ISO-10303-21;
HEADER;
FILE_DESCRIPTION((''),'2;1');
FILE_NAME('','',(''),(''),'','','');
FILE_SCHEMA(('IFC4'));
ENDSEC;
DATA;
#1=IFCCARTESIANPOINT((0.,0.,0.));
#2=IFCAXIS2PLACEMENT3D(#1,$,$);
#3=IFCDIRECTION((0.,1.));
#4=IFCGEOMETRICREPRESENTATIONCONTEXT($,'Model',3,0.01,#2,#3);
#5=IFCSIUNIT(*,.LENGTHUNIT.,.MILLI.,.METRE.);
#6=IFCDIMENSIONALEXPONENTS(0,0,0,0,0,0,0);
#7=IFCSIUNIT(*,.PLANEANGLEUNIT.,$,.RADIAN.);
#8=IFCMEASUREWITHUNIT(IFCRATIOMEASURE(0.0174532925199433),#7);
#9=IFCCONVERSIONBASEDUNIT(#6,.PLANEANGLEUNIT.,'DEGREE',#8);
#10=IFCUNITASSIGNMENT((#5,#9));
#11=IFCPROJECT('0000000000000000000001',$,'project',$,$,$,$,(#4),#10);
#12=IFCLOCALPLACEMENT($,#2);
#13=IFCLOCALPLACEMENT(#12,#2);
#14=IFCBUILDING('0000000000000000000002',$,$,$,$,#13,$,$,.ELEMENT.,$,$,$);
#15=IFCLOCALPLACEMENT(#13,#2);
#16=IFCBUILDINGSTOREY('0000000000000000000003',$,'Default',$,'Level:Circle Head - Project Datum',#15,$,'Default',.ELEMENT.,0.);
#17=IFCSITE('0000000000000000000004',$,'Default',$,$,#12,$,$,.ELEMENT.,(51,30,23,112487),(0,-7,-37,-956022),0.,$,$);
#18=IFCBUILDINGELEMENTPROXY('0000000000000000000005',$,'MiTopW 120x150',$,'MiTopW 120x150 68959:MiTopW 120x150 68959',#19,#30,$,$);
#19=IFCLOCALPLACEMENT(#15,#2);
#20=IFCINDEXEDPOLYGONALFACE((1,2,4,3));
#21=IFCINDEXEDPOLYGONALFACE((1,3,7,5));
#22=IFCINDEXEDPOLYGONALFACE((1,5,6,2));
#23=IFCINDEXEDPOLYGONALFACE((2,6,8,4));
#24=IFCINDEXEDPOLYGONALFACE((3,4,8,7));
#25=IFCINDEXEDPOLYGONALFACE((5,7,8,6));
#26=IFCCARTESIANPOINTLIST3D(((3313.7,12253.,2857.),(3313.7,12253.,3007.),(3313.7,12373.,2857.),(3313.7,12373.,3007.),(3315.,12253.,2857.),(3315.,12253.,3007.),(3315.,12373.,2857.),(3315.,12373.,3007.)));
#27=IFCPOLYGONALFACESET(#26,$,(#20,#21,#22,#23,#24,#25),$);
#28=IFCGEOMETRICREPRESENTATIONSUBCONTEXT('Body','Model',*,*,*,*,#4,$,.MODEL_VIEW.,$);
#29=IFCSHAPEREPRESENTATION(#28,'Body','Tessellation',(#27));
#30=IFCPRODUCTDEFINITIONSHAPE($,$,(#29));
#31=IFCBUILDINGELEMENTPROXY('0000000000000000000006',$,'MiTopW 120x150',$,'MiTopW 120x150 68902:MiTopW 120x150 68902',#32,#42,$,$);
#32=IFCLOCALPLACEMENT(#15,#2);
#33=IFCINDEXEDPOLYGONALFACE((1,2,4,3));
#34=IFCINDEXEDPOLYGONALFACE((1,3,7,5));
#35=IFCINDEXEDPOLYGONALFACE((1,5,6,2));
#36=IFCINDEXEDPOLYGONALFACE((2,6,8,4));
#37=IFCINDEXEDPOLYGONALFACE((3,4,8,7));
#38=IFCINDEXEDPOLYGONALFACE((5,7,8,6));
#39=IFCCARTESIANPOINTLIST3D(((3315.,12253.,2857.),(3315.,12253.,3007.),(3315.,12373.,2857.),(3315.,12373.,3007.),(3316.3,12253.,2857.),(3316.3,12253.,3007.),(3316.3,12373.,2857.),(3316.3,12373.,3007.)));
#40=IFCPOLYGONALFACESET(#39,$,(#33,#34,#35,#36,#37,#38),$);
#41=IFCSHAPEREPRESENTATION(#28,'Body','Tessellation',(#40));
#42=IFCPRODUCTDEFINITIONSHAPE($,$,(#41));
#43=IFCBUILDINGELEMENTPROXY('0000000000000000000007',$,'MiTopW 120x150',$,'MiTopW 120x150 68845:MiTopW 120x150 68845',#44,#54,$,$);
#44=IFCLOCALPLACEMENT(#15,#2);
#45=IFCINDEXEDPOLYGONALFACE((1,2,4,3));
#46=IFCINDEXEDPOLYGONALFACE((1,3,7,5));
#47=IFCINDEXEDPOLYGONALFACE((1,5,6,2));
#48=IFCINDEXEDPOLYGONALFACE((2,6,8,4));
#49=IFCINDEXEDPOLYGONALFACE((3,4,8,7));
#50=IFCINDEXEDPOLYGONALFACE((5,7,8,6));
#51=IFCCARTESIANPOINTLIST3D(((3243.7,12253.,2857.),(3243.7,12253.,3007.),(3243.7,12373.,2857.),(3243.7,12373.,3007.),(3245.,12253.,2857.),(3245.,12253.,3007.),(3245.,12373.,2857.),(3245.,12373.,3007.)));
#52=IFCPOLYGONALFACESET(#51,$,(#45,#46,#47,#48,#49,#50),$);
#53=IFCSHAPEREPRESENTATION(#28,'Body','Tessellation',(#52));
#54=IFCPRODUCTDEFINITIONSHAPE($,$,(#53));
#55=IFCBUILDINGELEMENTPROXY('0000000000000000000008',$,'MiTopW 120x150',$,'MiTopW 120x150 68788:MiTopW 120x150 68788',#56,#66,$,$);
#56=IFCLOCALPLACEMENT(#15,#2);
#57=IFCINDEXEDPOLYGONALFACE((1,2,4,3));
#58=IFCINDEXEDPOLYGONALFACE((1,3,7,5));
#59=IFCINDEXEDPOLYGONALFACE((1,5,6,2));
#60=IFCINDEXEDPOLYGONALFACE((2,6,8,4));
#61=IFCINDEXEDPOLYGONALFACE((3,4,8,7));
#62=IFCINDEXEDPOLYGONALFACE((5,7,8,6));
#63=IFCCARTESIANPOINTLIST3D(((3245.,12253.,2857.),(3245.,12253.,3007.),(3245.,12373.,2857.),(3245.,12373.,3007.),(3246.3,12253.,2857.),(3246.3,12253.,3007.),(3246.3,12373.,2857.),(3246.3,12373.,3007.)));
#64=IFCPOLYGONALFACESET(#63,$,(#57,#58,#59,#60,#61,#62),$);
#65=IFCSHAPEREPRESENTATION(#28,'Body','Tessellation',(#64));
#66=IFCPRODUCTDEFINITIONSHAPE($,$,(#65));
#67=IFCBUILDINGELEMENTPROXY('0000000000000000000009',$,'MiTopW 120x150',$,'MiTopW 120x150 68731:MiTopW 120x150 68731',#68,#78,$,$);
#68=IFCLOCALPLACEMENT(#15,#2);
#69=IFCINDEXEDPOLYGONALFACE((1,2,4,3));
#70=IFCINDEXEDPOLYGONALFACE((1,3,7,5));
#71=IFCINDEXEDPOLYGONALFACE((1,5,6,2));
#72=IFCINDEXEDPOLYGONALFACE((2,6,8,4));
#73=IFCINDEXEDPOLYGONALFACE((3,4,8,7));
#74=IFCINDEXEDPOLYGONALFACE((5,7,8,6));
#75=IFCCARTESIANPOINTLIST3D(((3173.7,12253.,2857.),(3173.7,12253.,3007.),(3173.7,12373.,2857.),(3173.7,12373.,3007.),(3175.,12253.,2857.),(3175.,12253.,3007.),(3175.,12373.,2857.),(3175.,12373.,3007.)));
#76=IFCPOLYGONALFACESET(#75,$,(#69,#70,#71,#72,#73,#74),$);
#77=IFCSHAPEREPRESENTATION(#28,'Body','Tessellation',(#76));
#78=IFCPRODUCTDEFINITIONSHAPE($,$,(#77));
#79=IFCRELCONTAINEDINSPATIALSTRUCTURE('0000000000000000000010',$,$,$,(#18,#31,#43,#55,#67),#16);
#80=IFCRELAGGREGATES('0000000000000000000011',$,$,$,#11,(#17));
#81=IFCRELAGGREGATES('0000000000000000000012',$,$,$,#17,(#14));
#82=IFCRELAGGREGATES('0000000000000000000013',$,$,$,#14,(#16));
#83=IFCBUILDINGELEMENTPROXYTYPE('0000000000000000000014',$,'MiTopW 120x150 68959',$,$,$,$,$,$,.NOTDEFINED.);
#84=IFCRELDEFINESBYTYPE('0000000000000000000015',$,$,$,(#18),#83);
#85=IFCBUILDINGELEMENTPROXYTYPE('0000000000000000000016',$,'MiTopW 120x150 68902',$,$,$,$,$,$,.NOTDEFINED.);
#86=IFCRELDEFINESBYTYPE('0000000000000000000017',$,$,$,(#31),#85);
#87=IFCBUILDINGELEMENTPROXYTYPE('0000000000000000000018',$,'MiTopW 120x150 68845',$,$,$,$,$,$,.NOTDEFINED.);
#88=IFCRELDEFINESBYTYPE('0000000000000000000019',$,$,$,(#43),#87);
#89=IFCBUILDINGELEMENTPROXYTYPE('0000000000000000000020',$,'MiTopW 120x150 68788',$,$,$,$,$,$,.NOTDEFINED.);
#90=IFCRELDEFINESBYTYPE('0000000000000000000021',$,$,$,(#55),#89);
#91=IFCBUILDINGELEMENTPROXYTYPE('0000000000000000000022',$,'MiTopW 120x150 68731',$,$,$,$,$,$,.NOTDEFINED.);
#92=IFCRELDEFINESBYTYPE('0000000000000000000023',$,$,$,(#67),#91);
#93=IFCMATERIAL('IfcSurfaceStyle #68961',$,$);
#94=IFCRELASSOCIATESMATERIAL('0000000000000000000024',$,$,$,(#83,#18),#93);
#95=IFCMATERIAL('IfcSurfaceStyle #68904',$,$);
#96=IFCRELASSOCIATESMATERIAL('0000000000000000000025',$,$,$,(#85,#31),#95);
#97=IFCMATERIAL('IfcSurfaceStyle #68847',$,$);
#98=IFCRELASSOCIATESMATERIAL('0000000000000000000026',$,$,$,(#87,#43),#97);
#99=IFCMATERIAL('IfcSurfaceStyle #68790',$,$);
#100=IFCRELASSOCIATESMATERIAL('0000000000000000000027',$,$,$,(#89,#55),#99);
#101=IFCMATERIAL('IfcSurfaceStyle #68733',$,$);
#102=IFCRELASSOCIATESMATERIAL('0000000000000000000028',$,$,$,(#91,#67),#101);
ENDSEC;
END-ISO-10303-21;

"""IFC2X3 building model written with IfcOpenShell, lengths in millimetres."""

from ifc_helpers import new_model, entity, si_unit, converted_unit, direction, frame, frame_2d, origin, place, context, subcontext, project, spatial, rectangle, extrude, source, transform, mapped, material, type_object, type_shapes, element, save


model = new_model("IFC2X3")

# Units and contexts
model_context = context("Model", 3, precision=0.01, world=origin(), true_north=direction((0.0, 1.0)))
body_context = subcontext(model_context, "Body", "Model", "MODEL_VIEW")
ifc_project = project(units=[si_unit("LENGTHUNIT", "METRE", prefix="MILLI"), converted_unit("PLANEANGLEUNIT", "DEGREE", entity("IfcRatioMeasure", 0.0174532925199433), si_unit("PLANEANGLEUNIT", "RADIAN"), dimensions=[0, 0, 0, 0, 0, 0, 0])], contexts=[model_context])

# Site, building, storey
site_placement = place(None, origin())
site = spatial("IfcSite", under=ifc_project, at=site_placement, Name="Default", CompositionType="ELEMENT", RefLatitude=(51, 30, 23, 112487), RefLongitude=(0, -7, -37, -956022), RefElevation=0.0)
building_placement = place(site_placement, origin())
building = spatial("IfcBuilding", under=site, at=building_placement, CompositionType="ELEMENT")
storey_placement = place(building_placement, origin())
storey = spatial("IfcBuildingStorey", under=building, at=storey_placement, Name="Default", ObjectType="Level:Circle Head - Project Datum", LongName="Default", CompositionType="ELEMENT", Elevation=0.0)

# Building element proxies
ifc_material_1 = material(Name="IfcSurfaceStyle #68961")
building_element_proxy_type_1 = type_object("IfcBuildingElementProxyType", Name="MiTopW 120x150 68959", PredefinedType="NOTDEFINED", material=ifc_material_1)
shared_shape_1 = source(origin(), body_context, "Body", "SweptSolid", [
    extrude(rectangle(XDim=150.0, YDim=120.0, at=frame_2d((0.0, 0.0), x_axis=(1.0, 0.0))), frame((75.0, 60.0, 0.0), z_axis=(0.0, 0.0, 1.0), x_axis=(-1.0, 0.0, 0.0)), (0.0, 0.0, 1.0), 1.3),
])
type_shapes(building_element_proxy_type_1, [shared_shape_1])
proxy_1_placement = place(building_placement, frame((3315.0, 12373.0, 3007.0), z_axis=(-1.0, 0.0, 0.0), x_axis=(0.0, 0.0, -1.0)))
element("IfcBuildingElementProxy", 1, at=proxy_1_placement, inside=storey, type_object=building_element_proxy_type_1, material=ifc_material_1, Name="MiTopW 120x150", ObjectType="MiTopW 120x150 68959:MiTopW 120x150 68959", context=body_context, shape_type="MappedRepresentation", body=[
    mapped(shared_shape_1, transform((0.0, 0.0, 0.0), scale=1.0)),
])
ifc_material_2 = material(Name="IfcSurfaceStyle #68904")
building_element_proxy_type_2 = type_object("IfcBuildingElementProxyType", Name="MiTopW 120x150 68902", PredefinedType="NOTDEFINED", material=ifc_material_2)
shared_shape_2 = source(origin(), body_context, "Body", "SweptSolid", [
    extrude(rectangle(XDim=150.0, YDim=120.0, at=frame_2d((0.0, 0.0), x_axis=(1.0, 0.0))), frame((75.0, 60.0, 0.0), z_axis=(0.0, 0.0, 1.0), x_axis=(-1.0, 0.0, 0.0)), (0.0, 0.0, 1.0), 1.3),
])
type_shapes(building_element_proxy_type_2, [shared_shape_2])
proxy_2_placement = place(building_placement, frame((3316.3, 12373.0, 3007.0), z_axis=(-1.0, 0.0, 0.0), x_axis=(0.0, 0.0, -1.0)))
element("IfcBuildingElementProxy", 2, at=proxy_2_placement, inside=storey, type_object=building_element_proxy_type_2, material=ifc_material_2, Name="MiTopW 120x150", ObjectType="MiTopW 120x150 68902:MiTopW 120x150 68902", context=body_context, shape_type="MappedRepresentation", body=[
    mapped(shared_shape_2, transform((0.0, 0.0, 0.0), scale=1.0)),
])
ifc_material_3 = material(Name="IfcSurfaceStyle #68847")
building_element_proxy_type_3 = type_object("IfcBuildingElementProxyType", Name="MiTopW 120x150 68845", PredefinedType="NOTDEFINED", material=ifc_material_3)
shared_shape_3 = source(origin(), body_context, "Body", "SweptSolid", [
    extrude(rectangle(XDim=150.0, YDim=120.0, at=frame_2d((0.0, 0.0), x_axis=(1.0, 0.0))), frame((75.0, 60.0, 0.0), z_axis=(0.0, 0.0, 1.0), x_axis=(-1.0, 0.0, 0.0)), (0.0, 0.0, 1.0), 1.3),
])
type_shapes(building_element_proxy_type_3, [shared_shape_3])
proxy_3_placement = place(building_placement, frame((3245.0, 12373.0, 3007.0), z_axis=(-1.0, 0.0, 0.0), x_axis=(0.0, 0.0, -1.0)))
element("IfcBuildingElementProxy", 3, at=proxy_3_placement, inside=storey, type_object=building_element_proxy_type_3, material=ifc_material_3, Name="MiTopW 120x150", ObjectType="MiTopW 120x150 68845:MiTopW 120x150 68845", context=body_context, shape_type="MappedRepresentation", body=[
    mapped(shared_shape_3, transform((0.0, 0.0, 0.0), scale=1.0)),
])
ifc_material_4 = material(Name="IfcSurfaceStyle #68790")
building_element_proxy_type_4 = type_object("IfcBuildingElementProxyType", Name="MiTopW 120x150 68788", PredefinedType="NOTDEFINED", material=ifc_material_4)
shared_shape_4 = source(origin(), body_context, "Body", "SweptSolid", [
    extrude(rectangle(XDim=150.0, YDim=120.0, at=frame_2d((0.0, 0.0), x_axis=(1.0, 0.0))), frame((75.0, 60.0, 0.0), z_axis=(0.0, 0.0, 1.0), x_axis=(-1.0, 0.0, 0.0)), (0.0, 0.0, 1.0), 1.3),
])
type_shapes(building_element_proxy_type_4, [shared_shape_4])
proxy_4_placement = place(building_placement, frame((3246.3, 12373.0, 3007.0), z_axis=(-1.0, 0.0, 0.0), x_axis=(0.0, 0.0, -1.0)))
element("IfcBuildingElementProxy", 4, at=proxy_4_placement, inside=storey, type_object=building_element_proxy_type_4, material=ifc_material_4, Name="MiTopW 120x150", ObjectType="MiTopW 120x150 68788:MiTopW 120x150 68788", context=body_context, shape_type="MappedRepresentation", body=[
    mapped(shared_shape_4, transform((0.0, 0.0, 0.0), scale=1.0)),
])
ifc_material_5 = material(Name="IfcSurfaceStyle #68733")
building_element_proxy_type_5 = type_object("IfcBuildingElementProxyType", Name="MiTopW 120x150 68731", PredefinedType="NOTDEFINED", material=ifc_material_5)
shared_shape_5 = source(origin(), body_context, "Body", "SweptSolid", [
    extrude(rectangle(XDim=150.0, YDim=120.0, at=frame_2d((0.0, 0.0), x_axis=(1.0, 0.0))), frame((75.0, 60.0, 0.0), z_axis=(0.0, 0.0, 1.0), x_axis=(-1.0, 0.0, 0.0)), (0.0, 0.0, 1.0), 1.3),
])
type_shapes(building_element_proxy_type_5, [shared_shape_5])
proxy_5_placement = place(building_placement, frame((3175.0, 12373.0, 3007.0), z_axis=(-1.0, 0.0, 0.0), x_axis=(0.0, 0.0, -1.0)))
element("IfcBuildingElementProxy", 5, at=proxy_5_placement, inside=storey, type_object=building_element_proxy_type_5, material=ifc_material_5, Name="MiTopW 120x150", ObjectType="MiTopW 120x150 68731:MiTopW 120x150 68731", context=body_context, shape_type="MappedRepresentation", body=[
    mapped(shared_shape_5, transform((0.0, 0.0, 0.0), scale=1.0)),
])

save(model, "model.ifc")
